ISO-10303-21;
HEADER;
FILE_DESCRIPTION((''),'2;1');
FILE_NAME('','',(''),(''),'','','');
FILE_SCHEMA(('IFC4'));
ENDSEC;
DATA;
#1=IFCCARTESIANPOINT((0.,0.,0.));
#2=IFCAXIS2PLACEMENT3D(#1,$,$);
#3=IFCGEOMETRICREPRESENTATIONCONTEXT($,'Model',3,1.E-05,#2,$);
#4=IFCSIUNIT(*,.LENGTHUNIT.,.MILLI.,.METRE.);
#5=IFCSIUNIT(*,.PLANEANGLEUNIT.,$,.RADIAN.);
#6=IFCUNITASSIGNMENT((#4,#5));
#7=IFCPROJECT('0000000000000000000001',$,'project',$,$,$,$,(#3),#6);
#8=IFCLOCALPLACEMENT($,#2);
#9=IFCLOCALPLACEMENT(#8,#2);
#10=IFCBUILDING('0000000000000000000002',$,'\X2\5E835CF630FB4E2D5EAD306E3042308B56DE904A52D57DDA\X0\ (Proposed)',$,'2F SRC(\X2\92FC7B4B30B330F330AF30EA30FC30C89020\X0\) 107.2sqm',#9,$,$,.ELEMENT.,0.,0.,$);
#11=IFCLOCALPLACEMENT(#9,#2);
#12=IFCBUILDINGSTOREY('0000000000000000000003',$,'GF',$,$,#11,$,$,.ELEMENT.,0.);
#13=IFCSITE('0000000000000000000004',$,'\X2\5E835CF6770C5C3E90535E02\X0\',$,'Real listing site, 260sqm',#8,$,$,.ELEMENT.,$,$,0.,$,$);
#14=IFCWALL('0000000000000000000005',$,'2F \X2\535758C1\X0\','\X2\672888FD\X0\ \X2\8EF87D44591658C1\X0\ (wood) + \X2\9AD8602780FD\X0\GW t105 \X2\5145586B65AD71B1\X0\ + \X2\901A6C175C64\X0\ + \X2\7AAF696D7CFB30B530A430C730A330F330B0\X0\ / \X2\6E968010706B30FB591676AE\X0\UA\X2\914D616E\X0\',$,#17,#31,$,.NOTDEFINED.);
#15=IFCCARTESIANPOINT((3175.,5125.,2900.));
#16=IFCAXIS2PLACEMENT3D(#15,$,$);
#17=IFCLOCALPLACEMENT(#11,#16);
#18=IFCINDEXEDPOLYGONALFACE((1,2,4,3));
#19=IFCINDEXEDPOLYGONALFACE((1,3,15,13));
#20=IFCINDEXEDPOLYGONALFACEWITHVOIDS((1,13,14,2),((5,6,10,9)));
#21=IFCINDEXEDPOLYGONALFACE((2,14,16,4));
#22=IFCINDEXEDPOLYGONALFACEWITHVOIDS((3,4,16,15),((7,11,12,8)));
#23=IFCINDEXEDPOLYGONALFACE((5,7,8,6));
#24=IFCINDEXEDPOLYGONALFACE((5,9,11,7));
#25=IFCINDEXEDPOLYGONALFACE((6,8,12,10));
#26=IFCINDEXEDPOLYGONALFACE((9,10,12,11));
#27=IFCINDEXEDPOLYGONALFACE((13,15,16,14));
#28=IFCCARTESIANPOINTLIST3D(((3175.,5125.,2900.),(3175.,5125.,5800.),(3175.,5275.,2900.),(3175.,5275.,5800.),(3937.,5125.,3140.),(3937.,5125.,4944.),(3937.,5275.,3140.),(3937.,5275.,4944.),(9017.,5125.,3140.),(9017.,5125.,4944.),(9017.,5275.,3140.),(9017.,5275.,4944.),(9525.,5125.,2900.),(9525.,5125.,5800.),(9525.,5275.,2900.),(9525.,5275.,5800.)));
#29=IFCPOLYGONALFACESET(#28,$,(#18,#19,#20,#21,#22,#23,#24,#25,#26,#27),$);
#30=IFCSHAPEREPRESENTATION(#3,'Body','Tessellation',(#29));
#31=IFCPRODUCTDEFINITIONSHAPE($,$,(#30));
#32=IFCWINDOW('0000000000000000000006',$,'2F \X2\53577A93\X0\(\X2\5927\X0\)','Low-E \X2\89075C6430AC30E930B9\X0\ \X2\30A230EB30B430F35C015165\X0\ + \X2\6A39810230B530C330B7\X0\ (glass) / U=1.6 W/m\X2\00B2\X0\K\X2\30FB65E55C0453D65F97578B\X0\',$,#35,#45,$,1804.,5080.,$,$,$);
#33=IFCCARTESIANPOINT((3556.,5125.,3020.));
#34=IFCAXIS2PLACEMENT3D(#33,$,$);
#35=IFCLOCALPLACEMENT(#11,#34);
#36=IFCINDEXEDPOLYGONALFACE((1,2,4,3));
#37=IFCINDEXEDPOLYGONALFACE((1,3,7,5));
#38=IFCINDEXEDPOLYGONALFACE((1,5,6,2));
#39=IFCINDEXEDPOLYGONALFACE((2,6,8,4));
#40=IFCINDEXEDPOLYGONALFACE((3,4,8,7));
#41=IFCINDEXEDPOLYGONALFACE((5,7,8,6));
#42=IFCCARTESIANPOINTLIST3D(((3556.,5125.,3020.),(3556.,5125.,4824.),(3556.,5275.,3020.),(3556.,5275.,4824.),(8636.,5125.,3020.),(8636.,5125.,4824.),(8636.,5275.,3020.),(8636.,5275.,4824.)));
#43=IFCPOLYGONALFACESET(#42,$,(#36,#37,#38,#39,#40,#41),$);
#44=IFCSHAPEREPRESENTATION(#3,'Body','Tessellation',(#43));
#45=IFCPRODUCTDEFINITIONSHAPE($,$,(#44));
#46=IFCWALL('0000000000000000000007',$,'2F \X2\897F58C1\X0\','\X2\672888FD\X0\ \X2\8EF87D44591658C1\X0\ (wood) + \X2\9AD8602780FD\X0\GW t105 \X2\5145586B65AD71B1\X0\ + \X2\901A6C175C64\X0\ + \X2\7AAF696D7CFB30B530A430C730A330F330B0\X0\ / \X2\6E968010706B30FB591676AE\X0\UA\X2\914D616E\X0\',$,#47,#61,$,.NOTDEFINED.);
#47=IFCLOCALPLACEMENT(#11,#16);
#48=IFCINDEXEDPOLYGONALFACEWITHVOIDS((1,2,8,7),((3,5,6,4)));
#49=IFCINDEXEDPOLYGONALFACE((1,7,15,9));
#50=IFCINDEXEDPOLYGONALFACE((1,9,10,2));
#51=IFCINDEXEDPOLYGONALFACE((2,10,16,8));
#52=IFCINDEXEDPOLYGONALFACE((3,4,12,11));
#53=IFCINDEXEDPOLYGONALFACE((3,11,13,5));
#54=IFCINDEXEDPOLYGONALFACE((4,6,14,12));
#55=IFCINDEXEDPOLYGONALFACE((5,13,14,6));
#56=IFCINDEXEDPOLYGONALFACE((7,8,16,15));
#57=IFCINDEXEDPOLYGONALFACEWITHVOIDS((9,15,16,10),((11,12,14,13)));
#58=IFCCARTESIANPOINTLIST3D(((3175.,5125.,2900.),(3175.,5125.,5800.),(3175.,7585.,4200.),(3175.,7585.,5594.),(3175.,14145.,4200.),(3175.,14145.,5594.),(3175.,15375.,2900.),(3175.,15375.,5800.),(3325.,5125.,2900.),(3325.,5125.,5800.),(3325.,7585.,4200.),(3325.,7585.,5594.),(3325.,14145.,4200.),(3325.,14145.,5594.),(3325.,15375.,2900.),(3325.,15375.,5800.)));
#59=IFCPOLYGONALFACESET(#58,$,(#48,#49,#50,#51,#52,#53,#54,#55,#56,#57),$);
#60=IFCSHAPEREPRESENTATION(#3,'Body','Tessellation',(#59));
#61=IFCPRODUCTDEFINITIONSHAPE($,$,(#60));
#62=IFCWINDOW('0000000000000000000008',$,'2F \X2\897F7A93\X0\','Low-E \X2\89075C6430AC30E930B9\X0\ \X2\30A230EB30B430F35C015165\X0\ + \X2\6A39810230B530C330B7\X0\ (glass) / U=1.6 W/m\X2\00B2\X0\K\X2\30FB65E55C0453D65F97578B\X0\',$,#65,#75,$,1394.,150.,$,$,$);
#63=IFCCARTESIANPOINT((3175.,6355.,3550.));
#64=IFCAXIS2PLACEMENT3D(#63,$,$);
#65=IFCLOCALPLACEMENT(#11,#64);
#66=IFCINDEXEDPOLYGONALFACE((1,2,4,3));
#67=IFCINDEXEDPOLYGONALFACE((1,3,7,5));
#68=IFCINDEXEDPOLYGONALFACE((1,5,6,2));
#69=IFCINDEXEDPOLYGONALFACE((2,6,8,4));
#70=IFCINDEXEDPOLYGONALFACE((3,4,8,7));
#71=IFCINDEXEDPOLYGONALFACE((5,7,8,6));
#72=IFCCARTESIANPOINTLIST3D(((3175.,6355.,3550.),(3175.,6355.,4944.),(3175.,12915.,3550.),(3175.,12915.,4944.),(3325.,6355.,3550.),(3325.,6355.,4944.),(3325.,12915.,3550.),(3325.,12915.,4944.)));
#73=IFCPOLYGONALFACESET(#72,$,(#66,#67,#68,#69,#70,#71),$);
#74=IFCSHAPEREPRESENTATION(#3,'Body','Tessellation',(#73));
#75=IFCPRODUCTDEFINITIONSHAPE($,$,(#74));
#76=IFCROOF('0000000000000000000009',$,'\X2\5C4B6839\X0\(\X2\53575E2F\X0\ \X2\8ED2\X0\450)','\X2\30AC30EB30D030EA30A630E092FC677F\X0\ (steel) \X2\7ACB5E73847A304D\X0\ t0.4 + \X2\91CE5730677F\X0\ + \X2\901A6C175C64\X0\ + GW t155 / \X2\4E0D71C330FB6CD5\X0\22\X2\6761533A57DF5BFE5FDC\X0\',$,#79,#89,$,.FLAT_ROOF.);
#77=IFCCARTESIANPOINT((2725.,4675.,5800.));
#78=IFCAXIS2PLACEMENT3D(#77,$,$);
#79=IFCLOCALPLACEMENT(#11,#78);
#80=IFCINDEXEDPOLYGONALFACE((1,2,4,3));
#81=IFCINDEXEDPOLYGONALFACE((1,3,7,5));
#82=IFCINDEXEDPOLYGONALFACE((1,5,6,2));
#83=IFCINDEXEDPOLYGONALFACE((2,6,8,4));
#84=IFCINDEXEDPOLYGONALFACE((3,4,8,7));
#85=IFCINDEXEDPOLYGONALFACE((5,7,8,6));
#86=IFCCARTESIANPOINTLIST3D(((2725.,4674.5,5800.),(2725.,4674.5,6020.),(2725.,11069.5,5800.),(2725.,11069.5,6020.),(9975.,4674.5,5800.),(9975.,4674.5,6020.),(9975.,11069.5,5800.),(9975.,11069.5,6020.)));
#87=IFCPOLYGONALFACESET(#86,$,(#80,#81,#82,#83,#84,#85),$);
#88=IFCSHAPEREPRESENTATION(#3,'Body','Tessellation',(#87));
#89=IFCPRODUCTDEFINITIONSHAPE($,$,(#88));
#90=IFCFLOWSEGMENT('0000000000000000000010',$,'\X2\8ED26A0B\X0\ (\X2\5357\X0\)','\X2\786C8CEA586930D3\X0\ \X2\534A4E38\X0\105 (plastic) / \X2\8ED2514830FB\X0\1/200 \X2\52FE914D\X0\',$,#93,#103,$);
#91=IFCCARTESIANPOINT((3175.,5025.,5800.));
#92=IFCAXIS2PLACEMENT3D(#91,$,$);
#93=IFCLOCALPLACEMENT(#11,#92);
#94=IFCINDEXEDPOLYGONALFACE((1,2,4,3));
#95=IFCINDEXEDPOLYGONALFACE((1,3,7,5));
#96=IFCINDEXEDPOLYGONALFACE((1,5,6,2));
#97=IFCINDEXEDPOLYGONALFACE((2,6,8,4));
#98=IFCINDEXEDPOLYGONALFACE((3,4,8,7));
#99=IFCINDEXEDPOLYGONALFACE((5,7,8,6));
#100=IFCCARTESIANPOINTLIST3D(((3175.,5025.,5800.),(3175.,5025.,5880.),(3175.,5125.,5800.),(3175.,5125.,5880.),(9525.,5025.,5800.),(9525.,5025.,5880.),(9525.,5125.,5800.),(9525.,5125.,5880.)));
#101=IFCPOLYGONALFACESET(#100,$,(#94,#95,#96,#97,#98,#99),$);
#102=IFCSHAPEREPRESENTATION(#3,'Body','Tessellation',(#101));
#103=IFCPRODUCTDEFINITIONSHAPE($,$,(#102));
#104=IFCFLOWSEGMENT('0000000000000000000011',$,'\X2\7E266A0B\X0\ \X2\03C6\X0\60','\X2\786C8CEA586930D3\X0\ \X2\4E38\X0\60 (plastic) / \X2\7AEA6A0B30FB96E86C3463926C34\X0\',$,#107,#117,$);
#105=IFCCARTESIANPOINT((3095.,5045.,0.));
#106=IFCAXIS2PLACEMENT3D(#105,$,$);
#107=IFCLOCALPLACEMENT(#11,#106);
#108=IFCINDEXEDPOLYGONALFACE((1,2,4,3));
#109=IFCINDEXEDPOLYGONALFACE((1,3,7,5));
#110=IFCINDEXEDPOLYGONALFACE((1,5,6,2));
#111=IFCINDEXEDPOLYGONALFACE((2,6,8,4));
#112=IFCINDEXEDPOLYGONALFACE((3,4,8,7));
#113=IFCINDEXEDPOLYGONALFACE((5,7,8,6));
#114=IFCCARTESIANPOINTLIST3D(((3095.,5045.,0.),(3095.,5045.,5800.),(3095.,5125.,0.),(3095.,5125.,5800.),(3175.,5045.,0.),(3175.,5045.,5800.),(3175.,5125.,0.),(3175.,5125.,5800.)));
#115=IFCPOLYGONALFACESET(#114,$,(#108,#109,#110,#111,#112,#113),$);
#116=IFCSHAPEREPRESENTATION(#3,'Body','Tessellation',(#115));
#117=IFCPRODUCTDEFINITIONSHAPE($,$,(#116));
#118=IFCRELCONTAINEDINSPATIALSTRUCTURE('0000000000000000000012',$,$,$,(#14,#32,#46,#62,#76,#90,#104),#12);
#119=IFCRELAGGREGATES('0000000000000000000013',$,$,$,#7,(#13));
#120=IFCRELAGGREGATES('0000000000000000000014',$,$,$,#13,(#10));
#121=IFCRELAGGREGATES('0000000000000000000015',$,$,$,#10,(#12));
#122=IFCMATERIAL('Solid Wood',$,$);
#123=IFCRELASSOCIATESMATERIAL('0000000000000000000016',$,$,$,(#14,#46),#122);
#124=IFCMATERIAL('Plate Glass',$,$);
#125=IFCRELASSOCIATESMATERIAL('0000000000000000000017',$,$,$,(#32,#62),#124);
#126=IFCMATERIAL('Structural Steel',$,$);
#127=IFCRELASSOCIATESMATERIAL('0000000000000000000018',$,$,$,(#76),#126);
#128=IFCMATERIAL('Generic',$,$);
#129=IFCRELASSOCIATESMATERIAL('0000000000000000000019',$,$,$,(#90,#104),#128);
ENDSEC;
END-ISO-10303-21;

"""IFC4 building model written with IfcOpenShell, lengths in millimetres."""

from ifc_helpers import new_model, si_unit, frame, frame_2d, origin, place, context, project, spatial, rectangle, extrude, material, element, fill, save


model = new_model("IFC4")

# Units and contexts
model_context = context("Model", 3, precision=1e-05, world=origin())
ifc_project = project(units=[si_unit("LENGTHUNIT", "METRE", prefix="MILLI"), si_unit("PLANEANGLEUNIT", "RADIAN")], contexts=[model_context])

# Site, building, storey
site_placement = place(None, origin())
site = spatial("IfcSite", under=ifc_project, at=site_placement, Name="広島県尾道市", ObjectType="Real listing site, 260sqm", CompositionType="ELEMENT", RefElevation=0.0)
building_placement = place(site_placement, origin())
building = spatial("IfcBuilding", under=site, at=building_placement, Name="広島・中庭のある回遊動線 (Proposed)", ObjectType="2F SRC(鋼筋コンクリート造) 107.2sqm", CompositionType="ELEMENT", ElevationOfRefHeight=0.0, ElevationOfTerrain=0.0)
storey_placement = place(building_placement, origin())
storey = spatial("IfcBuildingStorey", under=building, at=storey_placement, Name="GF", CompositionType="ELEMENT", Elevation=0.0)

# Shared definitions
ifc_material_1 = material(Name="Solid Wood")

# Shared definitions
ifc_material_2 = material(Name="Plate Glass")

# Walls, openings, windows
wall_1_placement = place(storey_placement, frame((3175.0, 5125.0, 2900.0)))
wall_1 = element("IfcWall", 1, at=wall_1_placement, inside=storey, material=ifc_material_1, Name="2F 南壁", Description="木製 軸組外壁 (wood) + 高性能GW t105 充填断熱 + 通気層 + 窯業系サイディング / 準耐火・外皮UA配慮", PredefinedType="NOTDEFINED", context=model_context, shape_type="SweptSolid", body=[
    extrude(rectangle(XDim=6350.0, YDim=150.0, at=frame_2d((3175.0, 75.0))), frame((3175.0, 5125.0, 2900.0)), (0.0, 0.0, 1.0), 2900.0),
])
opening_1_placement = place(storey_placement, frame((3556.0, 5125.0, 3020.0)))
opening_1 = element("IfcOpeningElement", 2, at=opening_1_placement, cuts=wall_1, PredefinedType="NOTDEFINED", context=model_context, shape_type="SweptSolid", body=[
    extrude(rectangle(XDim=5080.0, YDim=150.0, at=frame_2d((2540.0, 75.0))), frame((3556.0, 5125.0, 3020.0)), (0.0, 0.0, 1.0), 1804.0),
])
window_1_placement = place(storey_placement, frame((3556.0, 5125.0, 3020.0)))
window_1 = element("IfcWindow", 3, at=window_1_placement, inside=storey, material=ifc_material_2, Name="2F 南窓(大)", Description="Low-E 複層ガラス アルゴン封入 + 樹脂サッシ (glass) / U=1.6 W/m²K・日射取得型", OverallHeight=1804.0, OverallWidth=5080.0, context=model_context, shape_type="SweptSolid", body=[
    extrude(rectangle(XDim=5080.0, YDim=150.0, at=frame_2d((2540.0, 75.0))), frame((3556.0, 5125.0, 3020.0)), (0.0, 0.0, 1.0), 1804.0),
])
fill(opening_1, window_1)
wall_2_placement = place(storey_placement, frame((3175.0, 5125.0, 2900.0)))
wall_2 = element("IfcWall", 4, at=wall_2_placement, inside=storey, material=ifc_material_1, Name="2F 西壁", Description="木製 軸組外壁 (wood) + 高性能GW t105 充填断熱 + 通気層 + 窯業系サイディング / 準耐火・外皮UA配慮", PredefinedType="NOTDEFINED", context=model_context, shape_type="SweptSolid", body=[
    extrude(rectangle(XDim=150.0, YDim=10250.0, at=frame_2d((75.0, 5125.0))), frame((3175.0, 5125.0, 2900.0)), (0.0, 0.0, 1.0), 2900.0),
])
opening_2_placement = place(storey_placement, frame((3175.0, 6355.0, 3550.0)))
opening_2 = element("IfcOpeningElement", 5, at=opening_2_placement, cuts=wall_2, PredefinedType="NOTDEFINED", context=model_context, shape_type="SweptSolid", body=[
    extrude(rectangle(XDim=150.0, YDim=6560.0, at=frame_2d((75.0, 3280.0))), frame((3175.0, 6355.0, 3550.0)), (0.0, 0.0, 1.0), 1394.0),
])
window_2_placement = place(storey_placement, frame((3175.0, 6355.0, 3550.0)))
window_2 = element("IfcWindow", 6, at=window_2_placement, inside=storey, material=ifc_material_2, Name="2F 西窓", Description="Low-E 複層ガラス アルゴン封入 + 樹脂サッシ (glass) / U=1.6 W/m²K・日射取得型", OverallHeight=1394.0, OverallWidth=150.0, context=model_context, shape_type="SweptSolid", body=[
    extrude(rectangle(XDim=150.0, YDim=6560.0, at=frame_2d((75.0, 3280.0))), frame((3175.0, 6355.0, 3550.0)), (0.0, 0.0, 1.0), 1394.0),
])
fill(opening_2, window_2)

# Roof
ifc_material_3 = material(Name="Structural Steel")
for number, where, name in (
    (7, (2725.0, 4675.0, 5800.0), "屋根(南帯 軒450)"),
):
    element("IfcRoof", number, at=place(storey_placement, frame(where)), inside=storey, material=ifc_material_3, Name=name, Description="ガルバリウム鋼板 (steel) 立平葺き t0.4 + 野地板 + 通気層 + GW t155 / 不燃・法22条区域対応", PredefinedType="FLAT_ROOF", context=model_context, shape_type="SweptSolid", body=[
        extrude(rectangle(XDim=7250.0, YDim=6395.0, at=frame_2d((3625.0, 3197.0))), frame((2725.0, 4675.0, 5800.0)), (0.0, 0.0, 1.0), 220.0),
    ])

# Flow segments
ifc_material_4 = material(Name="Generic")
flow_segment_1_placement = place(storey_placement, frame((3175.0, 5025.0, 5800.0)))
element("IfcFlowSegment", 8, at=flow_segment_1_placement, inside=storey, material=ifc_material_4, Name="軒樋 (南)", Description="硬質塩ビ 半丸105 (plastic) / 軒先・1/200 勾配", context=model_context, shape_type="SweptSolid", body=[
    extrude(rectangle(XDim=6350.0, YDim=100.0, at=frame_2d((3175.0, 50.0))), frame((3175.0, 5025.0, 5800.0)), (0.0, 0.0, 1.0), 80.0),
])
flow_segment_2_placement = place(storey_placement, frame((3095.0, 5045.0, 0.0)))
element("IfcFlowSegment", 9, at=flow_segment_2_placement, inside=storey, material=ifc_material_4, Name="縦樋 φ60", Description="硬質塩ビ 丸60 (plastic) / 竪樋・雨水排水", context=model_context, shape_type="SweptSolid", body=[
    extrude(rectangle(XDim=80.0, YDim=80.0, at=frame_2d((40.0, 40.0))), frame((3095.0, 5045.0, 0.0)), (0.0, 0.0, 1.0), 5800.0),
])

save(model, "model.ifc")
